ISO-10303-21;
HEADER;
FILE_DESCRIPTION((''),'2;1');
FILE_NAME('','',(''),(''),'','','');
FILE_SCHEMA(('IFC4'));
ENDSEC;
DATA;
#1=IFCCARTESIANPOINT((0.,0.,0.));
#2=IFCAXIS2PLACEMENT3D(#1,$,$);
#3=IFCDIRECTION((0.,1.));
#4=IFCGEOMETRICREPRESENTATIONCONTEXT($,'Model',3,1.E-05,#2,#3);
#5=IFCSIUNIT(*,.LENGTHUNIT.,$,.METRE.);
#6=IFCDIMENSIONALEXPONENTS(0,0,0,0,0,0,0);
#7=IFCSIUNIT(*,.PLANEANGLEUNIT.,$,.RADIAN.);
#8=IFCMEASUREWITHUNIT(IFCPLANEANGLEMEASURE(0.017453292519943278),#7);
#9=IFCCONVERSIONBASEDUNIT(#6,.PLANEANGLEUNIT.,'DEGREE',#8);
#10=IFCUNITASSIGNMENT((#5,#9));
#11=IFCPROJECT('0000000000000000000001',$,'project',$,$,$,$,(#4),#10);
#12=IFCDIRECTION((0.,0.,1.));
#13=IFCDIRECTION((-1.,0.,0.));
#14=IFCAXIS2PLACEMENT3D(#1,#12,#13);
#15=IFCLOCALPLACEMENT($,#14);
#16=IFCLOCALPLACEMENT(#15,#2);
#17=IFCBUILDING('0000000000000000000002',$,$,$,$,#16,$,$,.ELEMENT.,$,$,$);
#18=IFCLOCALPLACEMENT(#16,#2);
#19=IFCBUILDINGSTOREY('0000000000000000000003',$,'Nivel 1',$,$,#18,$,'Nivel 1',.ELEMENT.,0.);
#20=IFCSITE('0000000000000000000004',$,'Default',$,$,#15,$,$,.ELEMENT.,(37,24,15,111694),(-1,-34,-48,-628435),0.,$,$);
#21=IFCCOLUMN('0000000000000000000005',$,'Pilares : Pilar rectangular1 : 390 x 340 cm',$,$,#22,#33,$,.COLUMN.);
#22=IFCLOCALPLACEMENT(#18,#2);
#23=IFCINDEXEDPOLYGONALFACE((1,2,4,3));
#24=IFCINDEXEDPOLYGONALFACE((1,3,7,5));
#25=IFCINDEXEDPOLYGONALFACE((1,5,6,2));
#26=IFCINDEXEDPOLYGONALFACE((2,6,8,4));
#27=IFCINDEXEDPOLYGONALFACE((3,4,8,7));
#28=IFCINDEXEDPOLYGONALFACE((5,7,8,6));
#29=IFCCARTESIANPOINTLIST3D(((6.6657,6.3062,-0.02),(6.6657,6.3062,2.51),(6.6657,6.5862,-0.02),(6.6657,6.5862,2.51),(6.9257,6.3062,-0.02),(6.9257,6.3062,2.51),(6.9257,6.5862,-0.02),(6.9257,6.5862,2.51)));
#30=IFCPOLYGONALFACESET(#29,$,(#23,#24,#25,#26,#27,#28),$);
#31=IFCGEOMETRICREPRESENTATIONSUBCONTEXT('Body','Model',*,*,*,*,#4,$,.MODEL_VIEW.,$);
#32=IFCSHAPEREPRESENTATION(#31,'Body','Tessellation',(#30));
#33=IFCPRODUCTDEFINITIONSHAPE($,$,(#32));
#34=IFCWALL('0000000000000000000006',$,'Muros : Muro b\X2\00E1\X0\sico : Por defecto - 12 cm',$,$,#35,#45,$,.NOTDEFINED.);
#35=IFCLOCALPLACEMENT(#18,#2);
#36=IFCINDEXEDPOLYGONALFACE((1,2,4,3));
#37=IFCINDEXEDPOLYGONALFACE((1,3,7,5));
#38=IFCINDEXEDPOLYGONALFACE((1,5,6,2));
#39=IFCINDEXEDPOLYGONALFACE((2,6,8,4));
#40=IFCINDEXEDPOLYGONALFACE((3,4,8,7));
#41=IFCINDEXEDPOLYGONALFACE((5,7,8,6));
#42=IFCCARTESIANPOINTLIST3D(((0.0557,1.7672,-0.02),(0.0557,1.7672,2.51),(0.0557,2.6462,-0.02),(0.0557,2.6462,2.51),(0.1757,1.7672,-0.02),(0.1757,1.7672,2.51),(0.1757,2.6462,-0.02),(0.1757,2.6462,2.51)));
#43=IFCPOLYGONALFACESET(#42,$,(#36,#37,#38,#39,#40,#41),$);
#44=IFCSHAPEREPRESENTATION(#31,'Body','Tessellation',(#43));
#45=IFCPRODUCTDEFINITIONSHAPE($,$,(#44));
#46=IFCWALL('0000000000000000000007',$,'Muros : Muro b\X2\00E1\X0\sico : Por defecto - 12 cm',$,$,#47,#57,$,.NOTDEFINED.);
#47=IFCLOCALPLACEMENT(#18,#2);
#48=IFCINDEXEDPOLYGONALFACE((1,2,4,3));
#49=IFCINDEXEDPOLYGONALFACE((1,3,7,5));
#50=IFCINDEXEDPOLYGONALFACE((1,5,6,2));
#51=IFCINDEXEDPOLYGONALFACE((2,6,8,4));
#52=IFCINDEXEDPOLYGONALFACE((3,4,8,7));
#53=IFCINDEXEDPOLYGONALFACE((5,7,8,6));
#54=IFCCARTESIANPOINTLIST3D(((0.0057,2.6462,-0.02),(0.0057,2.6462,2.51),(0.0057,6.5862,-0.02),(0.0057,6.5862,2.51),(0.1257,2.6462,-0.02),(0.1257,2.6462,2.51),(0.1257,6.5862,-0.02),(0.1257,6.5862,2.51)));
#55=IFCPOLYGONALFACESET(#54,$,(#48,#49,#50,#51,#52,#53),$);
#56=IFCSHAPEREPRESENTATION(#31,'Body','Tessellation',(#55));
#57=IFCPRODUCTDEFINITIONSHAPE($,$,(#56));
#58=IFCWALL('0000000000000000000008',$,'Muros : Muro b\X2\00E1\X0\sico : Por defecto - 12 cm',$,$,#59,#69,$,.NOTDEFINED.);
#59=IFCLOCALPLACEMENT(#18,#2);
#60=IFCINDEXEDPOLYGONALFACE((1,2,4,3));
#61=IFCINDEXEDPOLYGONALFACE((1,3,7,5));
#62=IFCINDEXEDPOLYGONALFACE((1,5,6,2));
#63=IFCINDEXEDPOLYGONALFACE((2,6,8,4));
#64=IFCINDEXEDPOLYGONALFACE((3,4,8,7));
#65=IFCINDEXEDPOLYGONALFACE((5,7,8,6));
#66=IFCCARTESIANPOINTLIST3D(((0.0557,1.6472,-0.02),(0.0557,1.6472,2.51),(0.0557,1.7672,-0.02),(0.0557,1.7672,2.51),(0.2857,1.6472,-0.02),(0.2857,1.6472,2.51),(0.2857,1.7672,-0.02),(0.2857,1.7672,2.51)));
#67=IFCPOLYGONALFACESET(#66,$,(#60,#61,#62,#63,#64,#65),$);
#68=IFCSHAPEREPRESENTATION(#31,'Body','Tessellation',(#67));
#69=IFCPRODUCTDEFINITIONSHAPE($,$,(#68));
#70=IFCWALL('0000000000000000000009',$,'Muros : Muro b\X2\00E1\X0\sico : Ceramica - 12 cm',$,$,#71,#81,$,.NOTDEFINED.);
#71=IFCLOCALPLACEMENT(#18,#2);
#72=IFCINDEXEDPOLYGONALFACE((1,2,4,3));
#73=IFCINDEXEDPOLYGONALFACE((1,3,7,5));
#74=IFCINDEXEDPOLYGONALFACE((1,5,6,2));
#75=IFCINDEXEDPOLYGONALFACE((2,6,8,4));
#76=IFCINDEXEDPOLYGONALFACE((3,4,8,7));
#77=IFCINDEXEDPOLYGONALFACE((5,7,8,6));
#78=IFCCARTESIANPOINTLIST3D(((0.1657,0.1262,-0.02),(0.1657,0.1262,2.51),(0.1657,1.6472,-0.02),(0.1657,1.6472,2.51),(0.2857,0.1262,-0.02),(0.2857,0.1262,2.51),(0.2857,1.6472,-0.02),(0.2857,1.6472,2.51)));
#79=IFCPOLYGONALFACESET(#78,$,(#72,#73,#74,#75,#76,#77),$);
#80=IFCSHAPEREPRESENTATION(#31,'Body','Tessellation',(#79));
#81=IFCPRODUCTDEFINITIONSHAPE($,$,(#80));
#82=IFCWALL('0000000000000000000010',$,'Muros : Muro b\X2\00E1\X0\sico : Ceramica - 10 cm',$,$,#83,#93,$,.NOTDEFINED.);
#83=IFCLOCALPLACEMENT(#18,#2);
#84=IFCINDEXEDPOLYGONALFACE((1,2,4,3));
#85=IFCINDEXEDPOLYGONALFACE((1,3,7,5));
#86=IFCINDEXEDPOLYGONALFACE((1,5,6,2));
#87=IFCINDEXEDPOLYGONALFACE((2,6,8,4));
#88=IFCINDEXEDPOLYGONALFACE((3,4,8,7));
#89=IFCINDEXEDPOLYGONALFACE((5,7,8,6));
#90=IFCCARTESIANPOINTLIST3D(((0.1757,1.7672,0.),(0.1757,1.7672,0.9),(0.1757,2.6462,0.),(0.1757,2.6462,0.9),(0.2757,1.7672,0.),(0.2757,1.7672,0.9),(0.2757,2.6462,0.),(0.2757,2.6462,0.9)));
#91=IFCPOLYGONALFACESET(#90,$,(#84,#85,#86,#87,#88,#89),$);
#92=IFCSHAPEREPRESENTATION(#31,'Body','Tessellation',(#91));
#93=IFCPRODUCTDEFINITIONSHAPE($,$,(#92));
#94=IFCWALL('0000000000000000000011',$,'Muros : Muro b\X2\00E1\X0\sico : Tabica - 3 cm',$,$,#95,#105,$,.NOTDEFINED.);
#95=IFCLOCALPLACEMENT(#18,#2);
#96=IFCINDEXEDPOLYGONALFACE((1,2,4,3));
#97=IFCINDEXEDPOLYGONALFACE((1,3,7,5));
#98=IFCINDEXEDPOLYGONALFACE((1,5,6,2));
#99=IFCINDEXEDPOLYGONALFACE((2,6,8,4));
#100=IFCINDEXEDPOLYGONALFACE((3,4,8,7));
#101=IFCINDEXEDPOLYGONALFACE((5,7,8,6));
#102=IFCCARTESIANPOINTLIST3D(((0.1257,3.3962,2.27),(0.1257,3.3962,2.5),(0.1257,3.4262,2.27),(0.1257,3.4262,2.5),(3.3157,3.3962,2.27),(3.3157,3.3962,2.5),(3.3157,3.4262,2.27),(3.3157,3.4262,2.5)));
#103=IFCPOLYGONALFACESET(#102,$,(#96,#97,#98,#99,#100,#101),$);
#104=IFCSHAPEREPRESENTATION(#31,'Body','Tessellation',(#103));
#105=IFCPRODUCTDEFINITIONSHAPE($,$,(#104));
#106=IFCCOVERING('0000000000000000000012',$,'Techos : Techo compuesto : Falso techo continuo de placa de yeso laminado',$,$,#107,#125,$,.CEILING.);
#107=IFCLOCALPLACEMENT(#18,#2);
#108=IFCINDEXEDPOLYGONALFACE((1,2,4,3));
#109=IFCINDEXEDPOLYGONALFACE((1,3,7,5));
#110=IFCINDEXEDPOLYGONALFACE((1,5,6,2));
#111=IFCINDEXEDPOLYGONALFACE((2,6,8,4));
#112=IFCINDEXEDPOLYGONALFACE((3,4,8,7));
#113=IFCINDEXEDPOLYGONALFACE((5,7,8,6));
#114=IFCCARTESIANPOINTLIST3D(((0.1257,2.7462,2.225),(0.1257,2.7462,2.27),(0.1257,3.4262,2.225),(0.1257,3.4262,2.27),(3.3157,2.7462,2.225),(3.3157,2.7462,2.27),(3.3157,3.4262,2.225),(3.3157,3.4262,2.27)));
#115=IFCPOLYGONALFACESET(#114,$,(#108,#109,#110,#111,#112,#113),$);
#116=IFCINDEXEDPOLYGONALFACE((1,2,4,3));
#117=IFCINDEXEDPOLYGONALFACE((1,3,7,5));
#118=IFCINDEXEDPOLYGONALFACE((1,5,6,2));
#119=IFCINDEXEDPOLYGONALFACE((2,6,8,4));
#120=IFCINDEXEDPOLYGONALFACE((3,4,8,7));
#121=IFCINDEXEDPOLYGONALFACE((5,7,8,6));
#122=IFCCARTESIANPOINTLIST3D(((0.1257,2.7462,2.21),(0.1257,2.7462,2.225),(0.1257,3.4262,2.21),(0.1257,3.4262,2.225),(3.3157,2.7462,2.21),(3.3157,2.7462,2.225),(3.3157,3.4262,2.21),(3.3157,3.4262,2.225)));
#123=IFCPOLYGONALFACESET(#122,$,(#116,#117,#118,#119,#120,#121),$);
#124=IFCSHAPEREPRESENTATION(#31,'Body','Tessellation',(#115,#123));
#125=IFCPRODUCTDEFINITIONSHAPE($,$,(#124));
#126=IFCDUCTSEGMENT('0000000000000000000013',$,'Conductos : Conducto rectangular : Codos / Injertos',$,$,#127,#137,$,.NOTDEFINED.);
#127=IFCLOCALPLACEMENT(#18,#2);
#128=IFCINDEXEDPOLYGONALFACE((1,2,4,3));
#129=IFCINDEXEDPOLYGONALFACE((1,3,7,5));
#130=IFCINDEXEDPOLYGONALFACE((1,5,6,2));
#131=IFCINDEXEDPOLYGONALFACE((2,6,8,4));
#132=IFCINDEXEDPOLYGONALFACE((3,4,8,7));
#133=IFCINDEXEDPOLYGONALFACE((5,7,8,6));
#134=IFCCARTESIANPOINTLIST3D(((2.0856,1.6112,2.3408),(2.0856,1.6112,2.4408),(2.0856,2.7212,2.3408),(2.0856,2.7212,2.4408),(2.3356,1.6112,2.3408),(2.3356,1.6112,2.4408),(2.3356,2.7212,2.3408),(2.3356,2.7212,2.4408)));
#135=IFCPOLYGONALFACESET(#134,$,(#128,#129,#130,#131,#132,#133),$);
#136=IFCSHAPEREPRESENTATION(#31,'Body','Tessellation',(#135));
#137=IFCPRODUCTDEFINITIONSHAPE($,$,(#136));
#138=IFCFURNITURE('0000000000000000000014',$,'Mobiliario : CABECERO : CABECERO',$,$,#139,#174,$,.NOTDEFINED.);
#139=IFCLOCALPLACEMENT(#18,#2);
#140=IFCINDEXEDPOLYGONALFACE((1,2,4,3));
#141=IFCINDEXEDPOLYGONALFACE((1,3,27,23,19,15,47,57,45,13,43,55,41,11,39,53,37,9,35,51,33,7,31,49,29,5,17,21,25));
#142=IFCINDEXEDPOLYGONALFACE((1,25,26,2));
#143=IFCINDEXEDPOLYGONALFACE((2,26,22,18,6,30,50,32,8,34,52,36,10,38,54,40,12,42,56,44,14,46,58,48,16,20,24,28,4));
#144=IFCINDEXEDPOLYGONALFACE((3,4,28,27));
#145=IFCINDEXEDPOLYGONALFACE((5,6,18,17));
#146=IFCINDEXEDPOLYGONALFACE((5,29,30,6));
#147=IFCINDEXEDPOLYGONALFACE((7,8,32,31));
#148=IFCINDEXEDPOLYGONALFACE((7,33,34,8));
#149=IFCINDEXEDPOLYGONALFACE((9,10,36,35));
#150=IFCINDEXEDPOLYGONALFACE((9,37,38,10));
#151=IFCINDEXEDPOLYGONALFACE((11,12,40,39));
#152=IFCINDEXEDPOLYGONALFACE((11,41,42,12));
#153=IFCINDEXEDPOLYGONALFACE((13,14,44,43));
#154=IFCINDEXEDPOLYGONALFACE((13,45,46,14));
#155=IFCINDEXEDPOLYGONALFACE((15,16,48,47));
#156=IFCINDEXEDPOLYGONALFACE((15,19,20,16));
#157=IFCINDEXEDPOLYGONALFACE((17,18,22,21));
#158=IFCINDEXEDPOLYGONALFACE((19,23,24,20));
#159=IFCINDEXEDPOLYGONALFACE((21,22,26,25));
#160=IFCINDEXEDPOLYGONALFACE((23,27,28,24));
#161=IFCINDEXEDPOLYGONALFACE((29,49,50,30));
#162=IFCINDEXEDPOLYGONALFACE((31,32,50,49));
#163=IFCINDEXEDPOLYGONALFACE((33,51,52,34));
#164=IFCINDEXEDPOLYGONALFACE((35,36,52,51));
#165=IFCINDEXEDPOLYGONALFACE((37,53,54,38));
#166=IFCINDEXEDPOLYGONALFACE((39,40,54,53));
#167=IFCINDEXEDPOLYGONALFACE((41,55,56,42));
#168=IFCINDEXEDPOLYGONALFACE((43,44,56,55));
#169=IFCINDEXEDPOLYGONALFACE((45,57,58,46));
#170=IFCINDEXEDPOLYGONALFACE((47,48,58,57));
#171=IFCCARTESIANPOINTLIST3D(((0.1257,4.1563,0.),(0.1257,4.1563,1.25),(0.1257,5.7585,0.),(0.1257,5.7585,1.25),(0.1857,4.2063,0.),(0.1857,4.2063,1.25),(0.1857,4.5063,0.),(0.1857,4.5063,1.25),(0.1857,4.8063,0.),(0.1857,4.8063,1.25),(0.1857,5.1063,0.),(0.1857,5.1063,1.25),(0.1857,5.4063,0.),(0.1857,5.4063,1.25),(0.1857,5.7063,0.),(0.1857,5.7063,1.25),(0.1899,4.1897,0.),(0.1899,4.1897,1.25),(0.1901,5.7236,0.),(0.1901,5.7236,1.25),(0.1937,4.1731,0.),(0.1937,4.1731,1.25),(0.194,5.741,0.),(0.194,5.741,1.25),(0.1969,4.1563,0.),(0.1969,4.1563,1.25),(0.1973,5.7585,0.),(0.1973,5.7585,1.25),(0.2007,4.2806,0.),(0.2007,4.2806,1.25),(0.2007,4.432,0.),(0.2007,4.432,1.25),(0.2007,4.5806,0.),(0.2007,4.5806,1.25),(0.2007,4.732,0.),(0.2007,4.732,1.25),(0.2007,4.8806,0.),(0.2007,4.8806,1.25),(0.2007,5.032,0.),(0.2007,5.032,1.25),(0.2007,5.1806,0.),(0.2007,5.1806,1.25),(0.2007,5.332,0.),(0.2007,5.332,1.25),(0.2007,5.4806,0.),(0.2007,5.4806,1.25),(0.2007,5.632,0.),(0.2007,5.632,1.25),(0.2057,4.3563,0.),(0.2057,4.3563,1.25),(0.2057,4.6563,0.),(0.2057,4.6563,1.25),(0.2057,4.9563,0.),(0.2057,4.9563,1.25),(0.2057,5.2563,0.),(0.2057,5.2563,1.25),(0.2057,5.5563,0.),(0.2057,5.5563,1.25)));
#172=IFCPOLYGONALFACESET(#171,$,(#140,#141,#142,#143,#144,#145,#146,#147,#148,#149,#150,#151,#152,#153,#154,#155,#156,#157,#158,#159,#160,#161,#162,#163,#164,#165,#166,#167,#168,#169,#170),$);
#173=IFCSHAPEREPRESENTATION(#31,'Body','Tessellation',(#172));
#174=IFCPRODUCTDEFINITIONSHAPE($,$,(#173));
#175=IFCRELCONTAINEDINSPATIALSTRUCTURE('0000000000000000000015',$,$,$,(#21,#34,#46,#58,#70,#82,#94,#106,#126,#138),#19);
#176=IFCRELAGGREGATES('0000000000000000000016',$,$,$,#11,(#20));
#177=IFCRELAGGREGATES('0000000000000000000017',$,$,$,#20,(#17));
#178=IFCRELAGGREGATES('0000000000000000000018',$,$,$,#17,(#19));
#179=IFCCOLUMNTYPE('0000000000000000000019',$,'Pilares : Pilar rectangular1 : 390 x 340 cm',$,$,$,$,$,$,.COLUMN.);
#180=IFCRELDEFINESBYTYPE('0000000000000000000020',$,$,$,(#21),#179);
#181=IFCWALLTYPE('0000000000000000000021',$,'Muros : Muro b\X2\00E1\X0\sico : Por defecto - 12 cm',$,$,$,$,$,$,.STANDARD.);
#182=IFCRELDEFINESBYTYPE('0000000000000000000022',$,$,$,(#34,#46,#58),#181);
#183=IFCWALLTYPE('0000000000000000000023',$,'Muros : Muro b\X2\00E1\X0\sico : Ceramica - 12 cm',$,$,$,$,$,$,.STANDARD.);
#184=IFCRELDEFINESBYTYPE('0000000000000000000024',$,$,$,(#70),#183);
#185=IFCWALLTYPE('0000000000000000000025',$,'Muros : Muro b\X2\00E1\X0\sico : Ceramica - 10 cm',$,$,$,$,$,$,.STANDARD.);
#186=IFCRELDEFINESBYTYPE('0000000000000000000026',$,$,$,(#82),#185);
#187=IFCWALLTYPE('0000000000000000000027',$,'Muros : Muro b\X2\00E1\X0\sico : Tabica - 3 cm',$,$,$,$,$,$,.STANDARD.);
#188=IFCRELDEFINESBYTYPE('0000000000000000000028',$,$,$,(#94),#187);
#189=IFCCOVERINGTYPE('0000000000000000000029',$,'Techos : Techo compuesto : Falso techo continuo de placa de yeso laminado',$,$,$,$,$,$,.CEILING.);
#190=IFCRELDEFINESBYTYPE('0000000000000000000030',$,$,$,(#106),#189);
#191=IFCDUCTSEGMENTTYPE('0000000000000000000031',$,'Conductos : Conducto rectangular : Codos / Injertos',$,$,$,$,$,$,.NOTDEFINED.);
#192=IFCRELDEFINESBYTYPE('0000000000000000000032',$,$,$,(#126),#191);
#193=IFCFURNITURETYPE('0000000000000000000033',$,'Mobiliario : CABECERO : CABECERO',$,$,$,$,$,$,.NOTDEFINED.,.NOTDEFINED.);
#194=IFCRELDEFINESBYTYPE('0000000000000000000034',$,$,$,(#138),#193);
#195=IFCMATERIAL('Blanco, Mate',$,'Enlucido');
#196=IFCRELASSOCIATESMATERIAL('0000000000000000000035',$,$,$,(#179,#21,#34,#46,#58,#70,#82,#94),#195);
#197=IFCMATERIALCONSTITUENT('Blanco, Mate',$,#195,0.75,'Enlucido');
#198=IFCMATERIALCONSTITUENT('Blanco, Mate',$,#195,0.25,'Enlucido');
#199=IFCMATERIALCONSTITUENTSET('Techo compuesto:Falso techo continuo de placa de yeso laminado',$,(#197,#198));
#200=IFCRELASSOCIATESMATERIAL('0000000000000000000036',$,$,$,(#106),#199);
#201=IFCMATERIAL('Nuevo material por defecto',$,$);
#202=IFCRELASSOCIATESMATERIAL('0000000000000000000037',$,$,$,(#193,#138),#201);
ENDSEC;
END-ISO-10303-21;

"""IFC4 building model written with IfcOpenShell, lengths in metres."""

from ifc_helpers import new_model, entity, si_unit, converted_unit, direction, frame, origin, place, context, subcontext, project, spatial, line, arc, indexed_curve, outline, extrude, source, transform, mapped, material, constituent, constituent_set, type_object, type_shapes, element, save


model = new_model("IFC4")

# Units and contexts
model_context = context("Model", 3, precision=1e-05, world=origin(), true_north=direction((0.0, 1.0)))
body_context = subcontext(model_context, "Body", "Model", "MODEL_VIEW")
ifc_project = project(units=[si_unit("LENGTHUNIT", "METRE"), converted_unit("PLANEANGLEUNIT", "DEGREE", entity("IfcPlaneAngleMeasure", 0.017453292519943278), si_unit("PLANEANGLEUNIT", "RADIAN"), dimensions=[0, 0, 0, 0, 0, 0, 0])], contexts=[model_context])

# Site, building, storey
site_placement = place(None, frame((0.0, 0.0, 0.0), z_axis=(0.0, 0.0, 1.0), x_axis=(-1.0, 0.0, 0.0)))
site = spatial("IfcSite", under=ifc_project, at=site_placement, Name="Default", CompositionType="ELEMENT", RefLatitude=(37, 24, 15, 111694), RefLongitude=(-1, -34, -48, -628435), RefElevation=0.0)
building_placement = place(site_placement, origin())
building = spatial("IfcBuilding", under=site, at=building_placement, CompositionType="ELEMENT")
storey_placement = place(building_placement, origin())
storey = spatial("IfcBuildingStorey", under=building, at=storey_placement, Name="Nivel 1", LongName="Nivel 1", CompositionType="ELEMENT", Elevation=0.0)

# Column
ifc_material_1 = material(Name="Blanco, Mate", Category="Enlucido")
column_type_1 = type_object("IfcColumnType", Name="Pilares : Pilar rectangular1 : 390 x 340 cm", PredefinedType="COLUMN", material=ifc_material_1)
shared_shape_1 = source(origin(), body_context, "Body", "SweptSolid", [
    extrude(outline(indexed_curve([(-0.14, -0.13), (0.14, -0.13), (0.14, 0.13), (-0.14, 0.13), (-0.14, -0.13)], self_intersect=False)), frame((6.7957, 6.4462, -0.02), z_axis=(0.0, 0.0, 1.0), x_axis=(0.0, 1.0, 0.0)), (0.0, 0.0, 1.0), 2.53),
])
type_shapes(column_type_1, [shared_shape_1])
column_1_placement = place(storey_placement, origin())
element("IfcColumn", 1, at=column_1_placement, inside=storey, type_object=column_type_1, material=ifc_material_1, Name="Pilares : Pilar rectangular1 : 390 x 340 cm", PredefinedType="COLUMN", context=body_context, shape_type="MappedRepresentation", body=[
    mapped(shared_shape_1, transform((0.0, 0.0, 0.0), scale=1.0)),
])

# Walls
wall_type_1 = type_object("IfcWallType", Name="Muros : Muro básico : Por defecto - 12 cm", PredefinedType="STANDARD")
wall_1_placement = place(storey_placement, frame((0.1157, 1.7672, -0.02), z_axis=(0.0, 0.0, 1.0), x_axis=(0.0, 1.0, 0.0)))
element("IfcWall", 2, at=wall_1_placement, inside=storey, type_object=wall_type_1, material=ifc_material_1, Name="Muros : Muro básico : Por defecto - 12 cm", PredefinedType="NOTDEFINED", context=body_context, shape_type="SweptSolid", body=[
    extrude(outline(indexed_curve([(0.8791, 0.06), (0.0, 0.06), (0.0, -0.06), (0.8791, -0.06), (0.8791, 0.06)], self_intersect=False)), origin(), (0.0, 0.0, 1.0), 2.53),
])
wall_2_placement = place(storey_placement, frame((0.0657, 2.6462, -0.02), z_axis=(0.0, 0.0, 1.0), x_axis=(0.0, 1.0, 0.0)))
element("IfcWall", 3, at=wall_2_placement, inside=storey, type_object=wall_type_1, material=ifc_material_1, Name="Muros : Muro básico : Por defecto - 12 cm", PredefinedType="NOTDEFINED", context=body_context, shape_type="SweptSolid", body=[
    extrude(outline(indexed_curve([(3.94, 0.06), (0.0, 0.06), (0.0, -0.06), (3.94, -0.06), (3.94, 0.06)], self_intersect=False)), origin(), (0.0, 0.0, 1.0), 2.53),
])
wall_3_placement = place(storey_placement, frame((0.0557, 1.7072, -0.02)))
element("IfcWall", 4, at=wall_3_placement, inside=storey, type_object=wall_type_1, material=ifc_material_1, Name="Muros : Muro básico : Por defecto - 12 cm", PredefinedType="NOTDEFINED", context=body_context, shape_type="SweptSolid", body=[
    extrude(outline(indexed_curve([(0.23, 0.06), (0.0, 0.06), (0.0, -0.06), (0.23, -0.06), (0.23, 0.06)], self_intersect=False)), origin(), (0.0, 0.0, 1.0), 2.53),
])
wall_type_2 = type_object("IfcWallType", Name="Muros : Muro básico : Ceramica - 12 cm", PredefinedType="STANDARD")
wall_4_placement = place(storey_placement, frame((0.2257, 1.6472, -0.02), z_axis=(0.0, 0.0, 1.0), x_axis=(0.0, -1.0, 0.0)))
element("IfcWall", 5, at=wall_4_placement, inside=storey, type_object=wall_type_2, material=ifc_material_1, Name="Muros : Muro básico : Ceramica - 12 cm", PredefinedType="NOTDEFINED", context=body_context, shape_type="SweptSolid", body=[
    extrude(outline(indexed_curve([(1.5209, 0.06), (0.0, 0.06), (0.0, -0.06), (1.5209, -0.06), (1.5209, 0.06)], self_intersect=False)), origin(), (0.0, 0.0, 1.0), 2.53),
])
wall_type_3 = type_object("IfcWallType", Name="Muros : Muro básico : Ceramica - 10 cm", PredefinedType="STANDARD")
wall_5_placement = place(storey_placement, frame((0.2257, 1.7672, 0.0), z_axis=(0.0, 0.0, 1.0), x_axis=(0.0, 1.0, 0.0)))
element("IfcWall", 6, at=wall_5_placement, inside=storey, type_object=wall_type_3, material=ifc_material_1, Name="Muros : Muro básico : Ceramica - 10 cm", PredefinedType="NOTDEFINED", context=body_context, shape_type="SweptSolid", body=[
    extrude(outline(indexed_curve([(0.8791, 0.05), (0.0, 0.05), (0.0, -0.05), (0.8791, -0.05), (0.8791, 0.05)], self_intersect=False)), origin(), (0.0, 0.0, 1.0), 0.9),
])
wall_type_4 = type_object("IfcWallType", Name="Muros : Muro básico : Tabica - 3 cm", PredefinedType="STANDARD")
wall_6_placement = place(storey_placement, frame((0.1257, 3.4112, 2.27)))
element("IfcWall", 7, at=wall_6_placement, inside=storey, type_object=wall_type_4, material=ifc_material_1, Name="Muros : Muro básico : Tabica - 3 cm", PredefinedType="NOTDEFINED", context=body_context, shape_type="SweptSolid", body=[
    extrude(outline(indexed_curve([(3.19, 0.015), (0.0, 0.015), (0.0, -0.015), (3.19, -0.015), (3.19, 0.015)], self_intersect=False)), origin(), (0.0, 0.0, 1.0), 0.23),
])

# Covering
ifc_constituent_1 = constituent(ifc_material_1, Name="Blanco, Mate", Category="Enlucido", fraction=0.75)
ifc_constituent_2 = constituent(ifc_material_1, Name="Blanco, Mate", Category="Enlucido", fraction=0.25)
ifc_constituent_set = constituent_set(constituents=[ifc_constituent_1, ifc_constituent_2], Name="Techo compuesto:Falso techo continuo de placa de yeso laminado")
covering_type_1 = type_object("IfcCoveringType", Name="Techos : Techo compuesto : Falso techo continuo de placa de yeso laminado", PredefinedType="CEILING")
covering_1_placement = place(storey_placement, origin())
element("IfcCovering", 8, at=covering_1_placement, inside=storey, type_object=covering_type_1, material=ifc_constituent_set, Name="Techos : Techo compuesto : Falso techo continuo de placa de yeso laminado", PredefinedType="CEILING", context=body_context, shape_type="SweptSolid", body=[
    extrude(outline(indexed_curve([(-0.34, -1.595), (0.34, -1.595), (0.34, 1.595), (-0.34, 1.595), (-0.34, -1.595)], self_intersect=False)), frame((1.7207, 3.0862, 2.225), z_axis=(0.0, 0.0, 1.0), x_axis=(0.0, -1.0, 0.0)), (0.0, 0.0, 1.0), 0.045),
    extrude(outline(indexed_curve([(-1.595, -0.34), (1.595, -0.34), (1.595, 0.34), (-1.595, 0.34), (-1.595, -0.34)], self_intersect=False)), frame((1.7207, 3.0862, 2.21), z_axis=(0.0, 0.0, 1.0), x_axis=(-1.0, 0.0, 0.0)), (0.0, 0.0, 1.0), 0.015),
])

# Duct segment
duct_segment_type = type_object("IfcDuctSegmentType", Name="Conductos : Conducto rectangular : Codos / Injertos", PredefinedType="NOTDEFINED")
duct_segment_placement = place(storey_placement, origin())
element("IfcDuctSegment", 9, at=duct_segment_placement, inside=storey, type_object=duct_segment_type, Name="Conductos : Conducto rectangular : Codos / Injertos", PredefinedType="NOTDEFINED", context=body_context, shape_type="SweptSolid", body=[
    extrude(outline(indexed_curve([(-0.555, -0.125), (0.555, -0.125), (0.555, 0.125), (-0.555, 0.125), (-0.555, -0.125)], self_intersect=False)), frame((2.2106, 2.1662, 2.3408), z_axis=(0.0, 0.0, 1.0), x_axis=(0.0, -1.0, 0.0)), (0.0, 0.0, 1.0), 0.1),
])

# Furniture
ifc_material_2 = material(Name="Nuevo material por defecto")
furniture_type_1 = type_object("IfcFurnitureType", Name="Mobiliario : CABECERO : CABECERO", AssemblyPlace="NOTDEFINED", PredefinedType="NOTDEFINED", material=ifc_material_2)
shared_shape_2 = source(origin(), body_context, "Body", "SweptSolid", [
    extrude(outline(indexed_curve([(-0.8018, -0.0503), (0.8004, -0.0503), (0.8004, 0.0209), (0.7753, 0.0159), (0.7504, 0.0097), (0.6004, 0.0297), (0.4504, 0.0097), (0.3004, 0.0297), (0.1504, 0.0097), (0.0004, 0.0297), (-0.1496, 0.0097), (-0.2996, 0.0297), (-0.4496, 0.0097), (-0.5996, 0.0297), (-0.7496, 0.0097), (-0.7755, 0.0161), (-0.8018, 0.0213)], segments=[line(1, 2, 3), arc(3, 4, 5), arc(5, 6, 7), arc(7, 8, 9), arc(9, 10, 11), arc(11, 12, 13), arc(13, 14, 15), arc(15, 16, 17), line(17, 1)], self_intersect=False)), frame((0.0004, -0.0103, 0.0), z_axis=(0.0, 0.0, 1.0), x_axis=(-1.0, 0.0, 0.0)), (0.0, 0.0, 1.0), 1.25),
])
type_shapes(furniture_type_1, [shared_shape_2])
furniture_1_placement = place(storey_placement, frame((0.1657, 4.9563, 0.0), z_axis=(0.0, 0.0, 1.0), x_axis=(0.0, 1.0, 0.0)))
element("IfcFurniture", 10, at=furniture_1_placement, inside=storey, type_object=furniture_type_1, material=ifc_material_2, Name="Mobiliario : CABECERO : CABECERO", PredefinedType="NOTDEFINED", context=body_context, shape_type="MappedRepresentation", body=[
    mapped(shared_shape_2, transform((0.0, 0.0, 0.0), scale=1.0)),
])

save(model, "model.ifc")
